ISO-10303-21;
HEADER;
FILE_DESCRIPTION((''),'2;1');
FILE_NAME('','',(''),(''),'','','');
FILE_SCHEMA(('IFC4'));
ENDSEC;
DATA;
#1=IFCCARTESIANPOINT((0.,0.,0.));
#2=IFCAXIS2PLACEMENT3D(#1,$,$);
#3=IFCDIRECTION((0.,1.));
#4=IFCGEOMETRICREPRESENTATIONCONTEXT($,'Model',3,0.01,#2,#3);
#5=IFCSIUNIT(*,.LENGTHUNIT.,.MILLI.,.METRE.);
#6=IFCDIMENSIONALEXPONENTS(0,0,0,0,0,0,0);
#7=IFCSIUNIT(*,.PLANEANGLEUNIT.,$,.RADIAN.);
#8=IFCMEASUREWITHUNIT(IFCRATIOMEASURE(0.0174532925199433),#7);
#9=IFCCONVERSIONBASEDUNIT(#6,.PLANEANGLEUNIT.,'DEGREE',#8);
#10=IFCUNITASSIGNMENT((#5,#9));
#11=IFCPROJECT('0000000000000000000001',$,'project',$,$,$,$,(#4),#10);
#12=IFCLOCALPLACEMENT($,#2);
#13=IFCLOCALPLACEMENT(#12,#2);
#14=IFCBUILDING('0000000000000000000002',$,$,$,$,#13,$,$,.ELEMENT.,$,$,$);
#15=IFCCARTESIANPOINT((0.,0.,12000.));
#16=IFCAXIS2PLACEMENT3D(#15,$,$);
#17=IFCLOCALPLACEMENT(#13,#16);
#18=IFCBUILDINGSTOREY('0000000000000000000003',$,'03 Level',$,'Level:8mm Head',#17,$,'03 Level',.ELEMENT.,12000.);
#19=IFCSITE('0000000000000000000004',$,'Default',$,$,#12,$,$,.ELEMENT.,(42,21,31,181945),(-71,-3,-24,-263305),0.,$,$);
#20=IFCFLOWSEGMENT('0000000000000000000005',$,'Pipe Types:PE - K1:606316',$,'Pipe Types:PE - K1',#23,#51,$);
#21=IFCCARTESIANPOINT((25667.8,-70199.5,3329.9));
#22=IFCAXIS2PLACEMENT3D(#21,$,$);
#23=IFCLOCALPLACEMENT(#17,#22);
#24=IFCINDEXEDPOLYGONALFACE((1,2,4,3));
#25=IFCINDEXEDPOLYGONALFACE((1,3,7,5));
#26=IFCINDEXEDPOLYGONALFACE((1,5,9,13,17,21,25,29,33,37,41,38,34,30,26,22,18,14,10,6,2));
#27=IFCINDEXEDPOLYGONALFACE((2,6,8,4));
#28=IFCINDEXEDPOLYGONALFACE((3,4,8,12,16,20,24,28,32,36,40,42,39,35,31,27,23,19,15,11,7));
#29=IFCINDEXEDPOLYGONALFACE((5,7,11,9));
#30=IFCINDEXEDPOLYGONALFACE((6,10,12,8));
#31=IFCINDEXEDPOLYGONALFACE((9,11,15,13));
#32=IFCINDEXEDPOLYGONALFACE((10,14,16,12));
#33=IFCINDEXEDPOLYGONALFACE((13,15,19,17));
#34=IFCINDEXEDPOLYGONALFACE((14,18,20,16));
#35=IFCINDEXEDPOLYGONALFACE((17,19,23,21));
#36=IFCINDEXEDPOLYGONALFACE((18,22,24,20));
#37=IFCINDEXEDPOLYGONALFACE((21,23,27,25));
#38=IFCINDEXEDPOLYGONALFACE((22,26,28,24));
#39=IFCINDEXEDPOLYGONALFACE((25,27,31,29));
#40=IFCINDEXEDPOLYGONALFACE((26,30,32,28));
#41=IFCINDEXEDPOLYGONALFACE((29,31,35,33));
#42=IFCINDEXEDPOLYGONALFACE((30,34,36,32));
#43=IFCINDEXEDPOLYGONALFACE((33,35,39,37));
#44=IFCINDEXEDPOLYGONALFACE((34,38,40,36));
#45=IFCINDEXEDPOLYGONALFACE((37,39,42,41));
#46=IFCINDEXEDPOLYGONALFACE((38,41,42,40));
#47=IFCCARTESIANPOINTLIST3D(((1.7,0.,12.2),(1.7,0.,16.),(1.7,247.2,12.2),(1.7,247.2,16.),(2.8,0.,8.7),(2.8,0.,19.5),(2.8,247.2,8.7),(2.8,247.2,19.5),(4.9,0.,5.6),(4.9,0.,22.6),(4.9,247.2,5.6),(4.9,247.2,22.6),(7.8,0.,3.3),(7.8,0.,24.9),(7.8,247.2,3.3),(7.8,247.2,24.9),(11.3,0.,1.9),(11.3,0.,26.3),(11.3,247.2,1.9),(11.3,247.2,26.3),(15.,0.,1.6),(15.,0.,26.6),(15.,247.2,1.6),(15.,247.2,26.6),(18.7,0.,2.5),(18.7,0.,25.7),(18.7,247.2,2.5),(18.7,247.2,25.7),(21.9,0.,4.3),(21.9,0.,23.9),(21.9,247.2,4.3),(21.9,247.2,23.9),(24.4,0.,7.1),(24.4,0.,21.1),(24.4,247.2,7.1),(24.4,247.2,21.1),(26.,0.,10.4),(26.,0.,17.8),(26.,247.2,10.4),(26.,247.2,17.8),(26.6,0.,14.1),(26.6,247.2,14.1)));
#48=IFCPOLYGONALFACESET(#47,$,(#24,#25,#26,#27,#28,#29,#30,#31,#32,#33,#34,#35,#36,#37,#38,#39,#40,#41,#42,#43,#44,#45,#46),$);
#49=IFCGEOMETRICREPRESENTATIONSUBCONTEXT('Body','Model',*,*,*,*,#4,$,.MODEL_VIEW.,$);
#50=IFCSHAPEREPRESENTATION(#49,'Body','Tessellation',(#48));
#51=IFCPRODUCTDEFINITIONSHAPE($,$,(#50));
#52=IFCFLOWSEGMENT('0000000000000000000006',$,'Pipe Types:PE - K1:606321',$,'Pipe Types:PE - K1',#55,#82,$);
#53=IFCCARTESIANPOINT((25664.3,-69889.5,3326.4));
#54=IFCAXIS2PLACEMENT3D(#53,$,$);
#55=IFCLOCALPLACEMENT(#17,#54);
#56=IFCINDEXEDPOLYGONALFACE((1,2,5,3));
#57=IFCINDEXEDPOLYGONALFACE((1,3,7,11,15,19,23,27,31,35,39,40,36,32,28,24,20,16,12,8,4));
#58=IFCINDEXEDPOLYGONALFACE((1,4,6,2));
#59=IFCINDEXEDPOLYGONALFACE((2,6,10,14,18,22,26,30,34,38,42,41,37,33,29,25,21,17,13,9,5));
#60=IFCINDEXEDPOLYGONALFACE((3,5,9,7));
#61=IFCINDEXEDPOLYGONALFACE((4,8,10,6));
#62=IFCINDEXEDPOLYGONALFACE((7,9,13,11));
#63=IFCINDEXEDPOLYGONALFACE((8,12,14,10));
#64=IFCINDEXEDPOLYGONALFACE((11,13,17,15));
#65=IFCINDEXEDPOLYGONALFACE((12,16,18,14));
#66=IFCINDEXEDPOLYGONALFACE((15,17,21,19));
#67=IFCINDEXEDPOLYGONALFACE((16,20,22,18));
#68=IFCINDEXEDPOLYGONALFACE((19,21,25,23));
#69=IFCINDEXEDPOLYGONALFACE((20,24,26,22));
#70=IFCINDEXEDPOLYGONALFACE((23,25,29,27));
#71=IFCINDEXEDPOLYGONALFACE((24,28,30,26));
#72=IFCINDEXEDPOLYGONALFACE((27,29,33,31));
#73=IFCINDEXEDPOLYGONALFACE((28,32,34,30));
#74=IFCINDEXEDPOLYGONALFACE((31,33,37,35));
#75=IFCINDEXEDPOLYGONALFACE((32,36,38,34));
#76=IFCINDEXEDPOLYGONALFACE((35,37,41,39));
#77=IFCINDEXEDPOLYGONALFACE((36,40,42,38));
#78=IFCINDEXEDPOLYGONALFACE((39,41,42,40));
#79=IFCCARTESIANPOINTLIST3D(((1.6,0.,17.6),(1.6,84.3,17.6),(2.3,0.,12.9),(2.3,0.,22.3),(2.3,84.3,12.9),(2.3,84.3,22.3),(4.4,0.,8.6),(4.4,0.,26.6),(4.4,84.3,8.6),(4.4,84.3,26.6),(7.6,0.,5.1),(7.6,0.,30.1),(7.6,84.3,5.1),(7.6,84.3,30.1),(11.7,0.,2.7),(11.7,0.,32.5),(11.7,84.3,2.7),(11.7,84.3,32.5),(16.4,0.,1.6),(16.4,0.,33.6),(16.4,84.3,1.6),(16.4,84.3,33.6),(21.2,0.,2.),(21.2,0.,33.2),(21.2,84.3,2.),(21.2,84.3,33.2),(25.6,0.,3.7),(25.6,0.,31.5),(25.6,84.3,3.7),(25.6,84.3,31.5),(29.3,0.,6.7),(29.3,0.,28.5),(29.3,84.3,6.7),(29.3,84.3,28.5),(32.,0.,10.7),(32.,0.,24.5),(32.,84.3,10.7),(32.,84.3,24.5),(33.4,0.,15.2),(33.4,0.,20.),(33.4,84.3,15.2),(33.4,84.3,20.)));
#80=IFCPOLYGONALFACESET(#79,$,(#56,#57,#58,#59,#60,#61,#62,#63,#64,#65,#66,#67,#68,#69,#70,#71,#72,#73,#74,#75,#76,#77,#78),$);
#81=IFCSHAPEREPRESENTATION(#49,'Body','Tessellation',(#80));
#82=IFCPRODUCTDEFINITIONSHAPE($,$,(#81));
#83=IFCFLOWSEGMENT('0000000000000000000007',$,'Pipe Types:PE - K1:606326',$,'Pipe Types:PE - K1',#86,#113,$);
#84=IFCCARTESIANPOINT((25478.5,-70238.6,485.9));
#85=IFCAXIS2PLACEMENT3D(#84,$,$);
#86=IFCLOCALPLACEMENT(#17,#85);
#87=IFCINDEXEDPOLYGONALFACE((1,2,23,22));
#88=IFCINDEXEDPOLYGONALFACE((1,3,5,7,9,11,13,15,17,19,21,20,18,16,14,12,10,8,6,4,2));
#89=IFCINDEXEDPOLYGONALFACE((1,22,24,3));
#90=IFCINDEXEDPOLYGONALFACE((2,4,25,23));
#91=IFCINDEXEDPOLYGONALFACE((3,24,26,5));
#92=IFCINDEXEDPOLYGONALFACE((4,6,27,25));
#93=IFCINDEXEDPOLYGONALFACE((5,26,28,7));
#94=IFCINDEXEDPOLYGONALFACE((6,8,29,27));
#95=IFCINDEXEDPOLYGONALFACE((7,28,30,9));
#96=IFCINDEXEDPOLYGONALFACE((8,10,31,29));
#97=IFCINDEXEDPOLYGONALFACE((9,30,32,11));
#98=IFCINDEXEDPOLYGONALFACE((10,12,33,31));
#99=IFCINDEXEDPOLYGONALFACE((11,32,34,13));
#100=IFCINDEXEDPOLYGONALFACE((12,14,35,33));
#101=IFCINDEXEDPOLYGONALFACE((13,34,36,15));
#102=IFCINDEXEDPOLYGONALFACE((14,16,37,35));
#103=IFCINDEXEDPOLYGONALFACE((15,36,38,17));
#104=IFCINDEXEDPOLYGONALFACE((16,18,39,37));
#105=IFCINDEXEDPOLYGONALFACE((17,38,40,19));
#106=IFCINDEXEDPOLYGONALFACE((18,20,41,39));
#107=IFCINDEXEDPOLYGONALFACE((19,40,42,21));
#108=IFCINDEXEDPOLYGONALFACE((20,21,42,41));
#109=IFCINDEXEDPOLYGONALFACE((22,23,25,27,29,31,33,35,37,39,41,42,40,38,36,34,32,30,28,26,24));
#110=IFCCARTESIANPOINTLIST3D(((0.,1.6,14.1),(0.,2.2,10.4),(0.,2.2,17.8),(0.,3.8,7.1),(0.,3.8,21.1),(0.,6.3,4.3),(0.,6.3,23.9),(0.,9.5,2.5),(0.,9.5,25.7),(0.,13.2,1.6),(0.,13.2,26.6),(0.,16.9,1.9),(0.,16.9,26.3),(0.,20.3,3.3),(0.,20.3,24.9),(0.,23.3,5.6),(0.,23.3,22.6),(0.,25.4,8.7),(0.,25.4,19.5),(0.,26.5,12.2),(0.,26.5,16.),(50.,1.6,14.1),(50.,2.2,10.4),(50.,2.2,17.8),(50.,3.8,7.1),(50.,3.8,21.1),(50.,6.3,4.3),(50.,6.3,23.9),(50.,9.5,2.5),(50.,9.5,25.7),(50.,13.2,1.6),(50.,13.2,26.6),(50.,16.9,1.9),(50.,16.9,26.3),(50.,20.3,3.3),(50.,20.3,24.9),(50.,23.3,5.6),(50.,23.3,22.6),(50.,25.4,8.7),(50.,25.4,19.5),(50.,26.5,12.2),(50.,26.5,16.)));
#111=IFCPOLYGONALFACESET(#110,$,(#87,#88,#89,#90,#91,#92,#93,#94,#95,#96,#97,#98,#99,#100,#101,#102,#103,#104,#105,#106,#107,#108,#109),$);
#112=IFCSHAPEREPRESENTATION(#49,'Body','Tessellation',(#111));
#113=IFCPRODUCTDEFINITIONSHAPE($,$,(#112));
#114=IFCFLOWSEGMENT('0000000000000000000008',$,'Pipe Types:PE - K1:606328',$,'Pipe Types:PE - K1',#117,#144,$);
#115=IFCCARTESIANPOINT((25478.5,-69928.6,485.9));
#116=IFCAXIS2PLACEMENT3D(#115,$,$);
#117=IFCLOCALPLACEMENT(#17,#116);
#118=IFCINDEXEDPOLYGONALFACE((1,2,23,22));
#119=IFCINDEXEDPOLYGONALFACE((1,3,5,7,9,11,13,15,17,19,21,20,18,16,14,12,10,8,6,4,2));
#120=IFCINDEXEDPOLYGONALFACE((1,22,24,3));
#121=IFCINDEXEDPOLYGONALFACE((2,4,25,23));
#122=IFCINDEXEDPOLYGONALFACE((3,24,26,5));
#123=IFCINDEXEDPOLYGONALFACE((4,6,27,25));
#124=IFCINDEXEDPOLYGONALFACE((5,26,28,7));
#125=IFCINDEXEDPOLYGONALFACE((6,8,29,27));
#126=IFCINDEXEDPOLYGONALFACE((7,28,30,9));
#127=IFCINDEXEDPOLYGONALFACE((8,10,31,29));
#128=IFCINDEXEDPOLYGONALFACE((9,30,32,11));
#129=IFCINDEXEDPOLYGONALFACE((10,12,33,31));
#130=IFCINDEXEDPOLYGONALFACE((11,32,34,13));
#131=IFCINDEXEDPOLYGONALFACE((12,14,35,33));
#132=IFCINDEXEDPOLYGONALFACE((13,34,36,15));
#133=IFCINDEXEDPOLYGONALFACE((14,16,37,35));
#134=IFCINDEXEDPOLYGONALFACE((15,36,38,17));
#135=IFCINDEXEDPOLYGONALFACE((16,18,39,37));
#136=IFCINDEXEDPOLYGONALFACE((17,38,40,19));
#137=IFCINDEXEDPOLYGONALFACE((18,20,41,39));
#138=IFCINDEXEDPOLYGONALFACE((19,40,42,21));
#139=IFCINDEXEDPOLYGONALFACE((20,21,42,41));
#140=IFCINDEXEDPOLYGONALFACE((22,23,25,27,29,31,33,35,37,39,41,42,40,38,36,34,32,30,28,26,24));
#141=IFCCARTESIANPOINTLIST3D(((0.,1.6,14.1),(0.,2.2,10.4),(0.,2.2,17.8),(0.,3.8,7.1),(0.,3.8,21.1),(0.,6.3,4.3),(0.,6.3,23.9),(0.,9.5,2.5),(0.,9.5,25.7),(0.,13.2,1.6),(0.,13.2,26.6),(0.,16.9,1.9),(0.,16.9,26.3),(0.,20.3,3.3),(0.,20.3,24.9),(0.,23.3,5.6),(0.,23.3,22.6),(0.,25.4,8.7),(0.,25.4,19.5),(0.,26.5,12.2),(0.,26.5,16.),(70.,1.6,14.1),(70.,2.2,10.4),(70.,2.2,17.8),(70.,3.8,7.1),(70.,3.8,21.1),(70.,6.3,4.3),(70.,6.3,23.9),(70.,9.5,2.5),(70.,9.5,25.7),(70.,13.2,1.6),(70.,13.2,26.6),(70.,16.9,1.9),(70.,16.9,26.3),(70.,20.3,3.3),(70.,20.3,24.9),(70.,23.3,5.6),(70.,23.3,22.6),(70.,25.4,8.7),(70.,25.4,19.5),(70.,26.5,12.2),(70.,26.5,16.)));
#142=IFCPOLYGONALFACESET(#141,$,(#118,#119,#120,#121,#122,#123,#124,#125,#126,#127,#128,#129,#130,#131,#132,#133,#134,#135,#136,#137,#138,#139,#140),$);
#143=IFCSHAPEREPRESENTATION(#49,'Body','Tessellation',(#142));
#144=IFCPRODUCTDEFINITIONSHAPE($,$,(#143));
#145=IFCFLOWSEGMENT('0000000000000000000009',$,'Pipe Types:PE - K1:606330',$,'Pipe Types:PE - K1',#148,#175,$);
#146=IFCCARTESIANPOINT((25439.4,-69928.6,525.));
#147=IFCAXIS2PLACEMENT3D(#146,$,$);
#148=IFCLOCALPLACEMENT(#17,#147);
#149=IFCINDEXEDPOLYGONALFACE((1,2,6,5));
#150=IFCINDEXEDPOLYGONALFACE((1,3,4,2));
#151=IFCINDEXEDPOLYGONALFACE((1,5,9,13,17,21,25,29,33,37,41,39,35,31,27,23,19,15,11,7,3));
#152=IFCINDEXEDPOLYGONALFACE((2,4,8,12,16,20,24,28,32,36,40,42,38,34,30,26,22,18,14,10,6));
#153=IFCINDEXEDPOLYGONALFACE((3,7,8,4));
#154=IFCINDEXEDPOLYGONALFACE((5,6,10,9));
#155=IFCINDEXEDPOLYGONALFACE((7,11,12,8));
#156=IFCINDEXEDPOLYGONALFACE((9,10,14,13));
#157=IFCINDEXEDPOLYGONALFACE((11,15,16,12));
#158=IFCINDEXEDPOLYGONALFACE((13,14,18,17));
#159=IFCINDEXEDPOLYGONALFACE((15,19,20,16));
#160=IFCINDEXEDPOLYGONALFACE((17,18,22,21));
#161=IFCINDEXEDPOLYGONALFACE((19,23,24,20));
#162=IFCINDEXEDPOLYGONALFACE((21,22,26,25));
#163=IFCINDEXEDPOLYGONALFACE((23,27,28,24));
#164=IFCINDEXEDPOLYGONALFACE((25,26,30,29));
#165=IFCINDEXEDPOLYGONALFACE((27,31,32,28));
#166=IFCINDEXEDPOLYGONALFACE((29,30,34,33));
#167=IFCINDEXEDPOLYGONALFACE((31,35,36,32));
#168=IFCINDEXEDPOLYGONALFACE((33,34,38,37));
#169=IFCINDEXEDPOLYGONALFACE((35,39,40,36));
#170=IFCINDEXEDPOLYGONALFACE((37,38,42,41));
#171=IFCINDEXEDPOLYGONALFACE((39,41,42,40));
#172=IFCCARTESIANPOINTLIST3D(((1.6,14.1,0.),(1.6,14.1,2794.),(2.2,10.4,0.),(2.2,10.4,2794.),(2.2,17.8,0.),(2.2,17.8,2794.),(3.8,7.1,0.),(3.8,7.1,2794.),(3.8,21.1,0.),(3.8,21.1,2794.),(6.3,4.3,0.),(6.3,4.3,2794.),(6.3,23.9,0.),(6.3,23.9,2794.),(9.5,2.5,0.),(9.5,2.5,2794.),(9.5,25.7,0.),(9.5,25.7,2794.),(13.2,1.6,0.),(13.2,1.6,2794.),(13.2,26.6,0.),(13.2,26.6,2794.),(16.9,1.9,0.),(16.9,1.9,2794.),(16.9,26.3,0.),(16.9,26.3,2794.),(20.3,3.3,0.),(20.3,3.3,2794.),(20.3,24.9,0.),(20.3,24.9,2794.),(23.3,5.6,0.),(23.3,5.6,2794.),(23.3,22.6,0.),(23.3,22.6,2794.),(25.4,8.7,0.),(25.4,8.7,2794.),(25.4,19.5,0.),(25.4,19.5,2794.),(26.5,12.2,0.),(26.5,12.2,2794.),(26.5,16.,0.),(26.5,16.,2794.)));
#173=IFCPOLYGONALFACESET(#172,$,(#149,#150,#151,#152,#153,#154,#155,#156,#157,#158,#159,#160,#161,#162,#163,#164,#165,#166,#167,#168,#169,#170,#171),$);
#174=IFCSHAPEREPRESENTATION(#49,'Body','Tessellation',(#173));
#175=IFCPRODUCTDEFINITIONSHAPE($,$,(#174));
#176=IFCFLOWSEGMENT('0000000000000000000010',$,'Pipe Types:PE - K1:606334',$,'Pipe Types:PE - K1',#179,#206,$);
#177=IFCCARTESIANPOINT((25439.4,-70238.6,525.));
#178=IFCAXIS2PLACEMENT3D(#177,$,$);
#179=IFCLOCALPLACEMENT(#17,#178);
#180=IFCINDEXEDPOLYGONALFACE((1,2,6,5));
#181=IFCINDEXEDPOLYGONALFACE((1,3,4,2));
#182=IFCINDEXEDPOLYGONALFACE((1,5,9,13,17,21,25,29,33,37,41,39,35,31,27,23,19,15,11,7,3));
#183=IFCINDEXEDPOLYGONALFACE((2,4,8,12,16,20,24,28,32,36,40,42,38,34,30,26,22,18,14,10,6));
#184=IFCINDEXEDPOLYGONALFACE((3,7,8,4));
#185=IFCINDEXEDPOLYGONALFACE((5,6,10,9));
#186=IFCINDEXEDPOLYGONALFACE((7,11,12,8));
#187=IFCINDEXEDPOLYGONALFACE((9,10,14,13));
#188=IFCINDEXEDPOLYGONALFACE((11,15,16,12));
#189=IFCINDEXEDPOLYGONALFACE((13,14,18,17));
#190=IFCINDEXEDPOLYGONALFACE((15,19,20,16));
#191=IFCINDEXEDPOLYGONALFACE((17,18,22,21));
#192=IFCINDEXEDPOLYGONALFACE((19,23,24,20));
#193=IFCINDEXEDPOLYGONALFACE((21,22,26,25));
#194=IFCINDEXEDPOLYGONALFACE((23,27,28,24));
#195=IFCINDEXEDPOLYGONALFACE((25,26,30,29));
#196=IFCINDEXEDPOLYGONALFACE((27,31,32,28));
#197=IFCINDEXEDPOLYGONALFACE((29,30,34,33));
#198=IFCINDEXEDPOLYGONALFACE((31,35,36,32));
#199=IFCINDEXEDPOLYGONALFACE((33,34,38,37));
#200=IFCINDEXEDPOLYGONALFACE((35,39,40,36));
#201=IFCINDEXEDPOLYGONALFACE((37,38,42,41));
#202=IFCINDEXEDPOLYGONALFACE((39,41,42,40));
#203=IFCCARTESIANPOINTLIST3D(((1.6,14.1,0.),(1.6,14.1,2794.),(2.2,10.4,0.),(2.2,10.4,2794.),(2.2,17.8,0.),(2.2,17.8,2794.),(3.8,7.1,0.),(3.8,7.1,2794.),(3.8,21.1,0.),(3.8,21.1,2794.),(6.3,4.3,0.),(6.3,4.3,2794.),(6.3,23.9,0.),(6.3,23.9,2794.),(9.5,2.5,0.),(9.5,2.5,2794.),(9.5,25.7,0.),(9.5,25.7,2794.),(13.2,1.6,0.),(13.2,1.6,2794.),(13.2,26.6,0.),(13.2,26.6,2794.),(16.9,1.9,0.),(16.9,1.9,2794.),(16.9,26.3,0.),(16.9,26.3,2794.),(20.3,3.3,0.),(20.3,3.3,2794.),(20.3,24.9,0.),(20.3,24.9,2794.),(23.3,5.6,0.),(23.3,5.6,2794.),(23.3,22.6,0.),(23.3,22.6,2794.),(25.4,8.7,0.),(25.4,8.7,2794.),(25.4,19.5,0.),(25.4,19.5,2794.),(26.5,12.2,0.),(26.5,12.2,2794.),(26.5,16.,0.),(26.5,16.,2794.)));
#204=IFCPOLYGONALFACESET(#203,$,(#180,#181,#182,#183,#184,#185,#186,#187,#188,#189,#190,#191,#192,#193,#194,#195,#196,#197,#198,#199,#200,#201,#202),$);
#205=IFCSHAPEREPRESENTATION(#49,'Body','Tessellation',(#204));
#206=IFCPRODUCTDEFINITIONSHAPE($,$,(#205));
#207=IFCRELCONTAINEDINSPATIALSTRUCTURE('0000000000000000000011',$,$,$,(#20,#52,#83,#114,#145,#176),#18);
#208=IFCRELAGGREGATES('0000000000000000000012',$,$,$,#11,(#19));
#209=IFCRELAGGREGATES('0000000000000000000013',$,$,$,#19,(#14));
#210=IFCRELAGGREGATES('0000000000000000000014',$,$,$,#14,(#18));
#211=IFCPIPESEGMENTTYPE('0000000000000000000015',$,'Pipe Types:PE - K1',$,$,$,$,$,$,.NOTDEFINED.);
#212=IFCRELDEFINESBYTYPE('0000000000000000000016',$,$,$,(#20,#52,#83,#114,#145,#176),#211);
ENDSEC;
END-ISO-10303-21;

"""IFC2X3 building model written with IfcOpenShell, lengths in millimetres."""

from ifc_helpers import new_model, entity, si_unit, converted_unit, direction, frame, frame_2d, origin, origin_2d_with_axis, place, context, subcontext, project, spatial, circle, extrude, type_object, element, save


model = new_model("IFC2X3")

# Units and contexts
model_context = context("Model", 3, precision=0.01, world=origin(), true_north=direction((0.0, 1.0)))
body_context = subcontext(model_context, "Body", "Model", "MODEL_VIEW")
ifc_project = project(units=[si_unit("LENGTHUNIT", "METRE", prefix="MILLI"), converted_unit("PLANEANGLEUNIT", "DEGREE", entity("IfcRatioMeasure", 0.0174532925199433), si_unit("PLANEANGLEUNIT", "RADIAN"), dimensions=[0, 0, 0, 0, 0, 0, 0])], contexts=[model_context])

# Site, building, storey
site_placement = place(None, origin())
site = spatial("IfcSite", under=ifc_project, at=site_placement, Name="Default", CompositionType="ELEMENT", RefLatitude=(42, 21, 31, 181945), RefLongitude=(-71, -3, -24, -263305), RefElevation=0.0)
building_placement = place(site_placement, origin())
building = spatial("IfcBuilding", under=site, at=building_placement, CompositionType="ELEMENT")
storey_placement = place(building_placement, frame((0.0, 0.0, 12000.0)))
storey = spatial("IfcBuildingStorey", under=building, at=storey_placement, Name="03 Level", ObjectType="Level:8mm Head", LongName="03 Level", CompositionType="ELEMENT", Elevation=12000.0)

# Flow segments
pipe_segment_type = type_object("IfcPipeSegmentType", Name="Pipe Types:PE - K1", PredefinedType="NOTDEFINED")
flow_segment_1_placement = place(storey_placement, frame((25667.8, -70199.5, 3329.9)))
element("IfcFlowSegment", 1, at=flow_segment_1_placement, inside=storey, type_object=pipe_segment_type, Name="Pipe Types:PE - K1:606316", ObjectType="Pipe Types:PE - K1", context=body_context, shape_type="SweptSolid", body=[
    extrude(circle(Radius=12.5, at=origin_2d_with_axis()), frame((14.1, 0.0, 14.1), z_axis=(0.0, 1.0, 0.0), x_axis=(1.0, 0.0, 0.0)), (0.0, 0.0, 1.0), 247.2),
])
flow_segment_2_placement = place(storey_placement, frame((25664.3, -69889.5, 3326.4)))
element("IfcFlowSegment", 2, at=flow_segment_2_placement, inside=storey, type_object=pipe_segment_type, Name="Pipe Types:PE - K1:606321", ObjectType="Pipe Types:PE - K1", context=body_context, shape_type="SweptSolid", body=[
    extrude(circle(Radius=16.0, at=origin_2d_with_axis()), frame((17.6, 0.0, 17.6), z_axis=(0.0, 1.0, 0.0), x_axis=(-1.0, 0.0, 0.0)), (0.0, 0.0, 1.0), 84.3),
])
flow_segment_3_placement = place(storey_placement, frame((25478.5, -70238.6, 485.9)))
element("IfcFlowSegment", 3, at=flow_segment_3_placement, inside=storey, type_object=pipe_segment_type, Name="Pipe Types:PE - K1:606326", ObjectType="Pipe Types:PE - K1", context=body_context, shape_type="SweptSolid", body=[
    extrude(circle(Radius=12.5, at=origin_2d_with_axis()), frame((0.0, 14.1, 14.1), z_axis=(1.0, 0.0, 0.0), x_axis=(0.0, -1.0, 0.0)), (0.0, 0.0, 1.0), 50.0),
])
flow_segment_4_placement = place(storey_placement, frame((25478.5, -69928.6, 485.9)))
element("IfcFlowSegment", 4, at=flow_segment_4_placement, inside=storey, type_object=pipe_segment_type, Name="Pipe Types:PE - K1:606328", ObjectType="Pipe Types:PE - K1", context=body_context, shape_type="SweptSolid", body=[
    extrude(circle(Radius=12.5, at=origin_2d_with_axis()), frame((0.0, 14.1, 14.1), z_axis=(1.0, 0.0, 0.0), x_axis=(0.0, -1.0, 0.0)), (0.0, 0.0, 1.0), 70.0),
])
flow_segment_5_placement = place(storey_placement, frame((25439.4, -69928.6, 525.0)))
element("IfcFlowSegment", 5, at=flow_segment_5_placement, inside=storey, type_object=pipe_segment_type, Name="Pipe Types:PE - K1:606330", ObjectType="Pipe Types:PE - K1", context=body_context, shape_type="SweptSolid", body=[
    extrude(circle(Radius=12.5, at=frame_2d((0.0, 0.0), x_axis=(1.0, 0.0))), frame((14.1, 14.1, 0.0), z_axis=(0.0, 0.0, 1.0), x_axis=(-1.0, 0.0, 0.0)), (0.0, 0.0, 1.0), 2794.0),
])
flow_segment_6_placement = place(storey_placement, frame((25439.4, -70238.6, 525.0)))
element("IfcFlowSegment", 6, at=flow_segment_6_placement, inside=storey, type_object=pipe_segment_type, Name="Pipe Types:PE - K1:606334", ObjectType="Pipe Types:PE - K1", context=body_context, shape_type="SweptSolid", body=[
    extrude(circle(Radius=12.5, at=origin_2d_with_axis()), frame((14.1, 14.1, 0.0), z_axis=(0.0, 0.0, 1.0), x_axis=(-1.0, 0.0, 0.0)), (0.0, 0.0, 1.0), 2794.0),
])

save(model, "model.ifc")
